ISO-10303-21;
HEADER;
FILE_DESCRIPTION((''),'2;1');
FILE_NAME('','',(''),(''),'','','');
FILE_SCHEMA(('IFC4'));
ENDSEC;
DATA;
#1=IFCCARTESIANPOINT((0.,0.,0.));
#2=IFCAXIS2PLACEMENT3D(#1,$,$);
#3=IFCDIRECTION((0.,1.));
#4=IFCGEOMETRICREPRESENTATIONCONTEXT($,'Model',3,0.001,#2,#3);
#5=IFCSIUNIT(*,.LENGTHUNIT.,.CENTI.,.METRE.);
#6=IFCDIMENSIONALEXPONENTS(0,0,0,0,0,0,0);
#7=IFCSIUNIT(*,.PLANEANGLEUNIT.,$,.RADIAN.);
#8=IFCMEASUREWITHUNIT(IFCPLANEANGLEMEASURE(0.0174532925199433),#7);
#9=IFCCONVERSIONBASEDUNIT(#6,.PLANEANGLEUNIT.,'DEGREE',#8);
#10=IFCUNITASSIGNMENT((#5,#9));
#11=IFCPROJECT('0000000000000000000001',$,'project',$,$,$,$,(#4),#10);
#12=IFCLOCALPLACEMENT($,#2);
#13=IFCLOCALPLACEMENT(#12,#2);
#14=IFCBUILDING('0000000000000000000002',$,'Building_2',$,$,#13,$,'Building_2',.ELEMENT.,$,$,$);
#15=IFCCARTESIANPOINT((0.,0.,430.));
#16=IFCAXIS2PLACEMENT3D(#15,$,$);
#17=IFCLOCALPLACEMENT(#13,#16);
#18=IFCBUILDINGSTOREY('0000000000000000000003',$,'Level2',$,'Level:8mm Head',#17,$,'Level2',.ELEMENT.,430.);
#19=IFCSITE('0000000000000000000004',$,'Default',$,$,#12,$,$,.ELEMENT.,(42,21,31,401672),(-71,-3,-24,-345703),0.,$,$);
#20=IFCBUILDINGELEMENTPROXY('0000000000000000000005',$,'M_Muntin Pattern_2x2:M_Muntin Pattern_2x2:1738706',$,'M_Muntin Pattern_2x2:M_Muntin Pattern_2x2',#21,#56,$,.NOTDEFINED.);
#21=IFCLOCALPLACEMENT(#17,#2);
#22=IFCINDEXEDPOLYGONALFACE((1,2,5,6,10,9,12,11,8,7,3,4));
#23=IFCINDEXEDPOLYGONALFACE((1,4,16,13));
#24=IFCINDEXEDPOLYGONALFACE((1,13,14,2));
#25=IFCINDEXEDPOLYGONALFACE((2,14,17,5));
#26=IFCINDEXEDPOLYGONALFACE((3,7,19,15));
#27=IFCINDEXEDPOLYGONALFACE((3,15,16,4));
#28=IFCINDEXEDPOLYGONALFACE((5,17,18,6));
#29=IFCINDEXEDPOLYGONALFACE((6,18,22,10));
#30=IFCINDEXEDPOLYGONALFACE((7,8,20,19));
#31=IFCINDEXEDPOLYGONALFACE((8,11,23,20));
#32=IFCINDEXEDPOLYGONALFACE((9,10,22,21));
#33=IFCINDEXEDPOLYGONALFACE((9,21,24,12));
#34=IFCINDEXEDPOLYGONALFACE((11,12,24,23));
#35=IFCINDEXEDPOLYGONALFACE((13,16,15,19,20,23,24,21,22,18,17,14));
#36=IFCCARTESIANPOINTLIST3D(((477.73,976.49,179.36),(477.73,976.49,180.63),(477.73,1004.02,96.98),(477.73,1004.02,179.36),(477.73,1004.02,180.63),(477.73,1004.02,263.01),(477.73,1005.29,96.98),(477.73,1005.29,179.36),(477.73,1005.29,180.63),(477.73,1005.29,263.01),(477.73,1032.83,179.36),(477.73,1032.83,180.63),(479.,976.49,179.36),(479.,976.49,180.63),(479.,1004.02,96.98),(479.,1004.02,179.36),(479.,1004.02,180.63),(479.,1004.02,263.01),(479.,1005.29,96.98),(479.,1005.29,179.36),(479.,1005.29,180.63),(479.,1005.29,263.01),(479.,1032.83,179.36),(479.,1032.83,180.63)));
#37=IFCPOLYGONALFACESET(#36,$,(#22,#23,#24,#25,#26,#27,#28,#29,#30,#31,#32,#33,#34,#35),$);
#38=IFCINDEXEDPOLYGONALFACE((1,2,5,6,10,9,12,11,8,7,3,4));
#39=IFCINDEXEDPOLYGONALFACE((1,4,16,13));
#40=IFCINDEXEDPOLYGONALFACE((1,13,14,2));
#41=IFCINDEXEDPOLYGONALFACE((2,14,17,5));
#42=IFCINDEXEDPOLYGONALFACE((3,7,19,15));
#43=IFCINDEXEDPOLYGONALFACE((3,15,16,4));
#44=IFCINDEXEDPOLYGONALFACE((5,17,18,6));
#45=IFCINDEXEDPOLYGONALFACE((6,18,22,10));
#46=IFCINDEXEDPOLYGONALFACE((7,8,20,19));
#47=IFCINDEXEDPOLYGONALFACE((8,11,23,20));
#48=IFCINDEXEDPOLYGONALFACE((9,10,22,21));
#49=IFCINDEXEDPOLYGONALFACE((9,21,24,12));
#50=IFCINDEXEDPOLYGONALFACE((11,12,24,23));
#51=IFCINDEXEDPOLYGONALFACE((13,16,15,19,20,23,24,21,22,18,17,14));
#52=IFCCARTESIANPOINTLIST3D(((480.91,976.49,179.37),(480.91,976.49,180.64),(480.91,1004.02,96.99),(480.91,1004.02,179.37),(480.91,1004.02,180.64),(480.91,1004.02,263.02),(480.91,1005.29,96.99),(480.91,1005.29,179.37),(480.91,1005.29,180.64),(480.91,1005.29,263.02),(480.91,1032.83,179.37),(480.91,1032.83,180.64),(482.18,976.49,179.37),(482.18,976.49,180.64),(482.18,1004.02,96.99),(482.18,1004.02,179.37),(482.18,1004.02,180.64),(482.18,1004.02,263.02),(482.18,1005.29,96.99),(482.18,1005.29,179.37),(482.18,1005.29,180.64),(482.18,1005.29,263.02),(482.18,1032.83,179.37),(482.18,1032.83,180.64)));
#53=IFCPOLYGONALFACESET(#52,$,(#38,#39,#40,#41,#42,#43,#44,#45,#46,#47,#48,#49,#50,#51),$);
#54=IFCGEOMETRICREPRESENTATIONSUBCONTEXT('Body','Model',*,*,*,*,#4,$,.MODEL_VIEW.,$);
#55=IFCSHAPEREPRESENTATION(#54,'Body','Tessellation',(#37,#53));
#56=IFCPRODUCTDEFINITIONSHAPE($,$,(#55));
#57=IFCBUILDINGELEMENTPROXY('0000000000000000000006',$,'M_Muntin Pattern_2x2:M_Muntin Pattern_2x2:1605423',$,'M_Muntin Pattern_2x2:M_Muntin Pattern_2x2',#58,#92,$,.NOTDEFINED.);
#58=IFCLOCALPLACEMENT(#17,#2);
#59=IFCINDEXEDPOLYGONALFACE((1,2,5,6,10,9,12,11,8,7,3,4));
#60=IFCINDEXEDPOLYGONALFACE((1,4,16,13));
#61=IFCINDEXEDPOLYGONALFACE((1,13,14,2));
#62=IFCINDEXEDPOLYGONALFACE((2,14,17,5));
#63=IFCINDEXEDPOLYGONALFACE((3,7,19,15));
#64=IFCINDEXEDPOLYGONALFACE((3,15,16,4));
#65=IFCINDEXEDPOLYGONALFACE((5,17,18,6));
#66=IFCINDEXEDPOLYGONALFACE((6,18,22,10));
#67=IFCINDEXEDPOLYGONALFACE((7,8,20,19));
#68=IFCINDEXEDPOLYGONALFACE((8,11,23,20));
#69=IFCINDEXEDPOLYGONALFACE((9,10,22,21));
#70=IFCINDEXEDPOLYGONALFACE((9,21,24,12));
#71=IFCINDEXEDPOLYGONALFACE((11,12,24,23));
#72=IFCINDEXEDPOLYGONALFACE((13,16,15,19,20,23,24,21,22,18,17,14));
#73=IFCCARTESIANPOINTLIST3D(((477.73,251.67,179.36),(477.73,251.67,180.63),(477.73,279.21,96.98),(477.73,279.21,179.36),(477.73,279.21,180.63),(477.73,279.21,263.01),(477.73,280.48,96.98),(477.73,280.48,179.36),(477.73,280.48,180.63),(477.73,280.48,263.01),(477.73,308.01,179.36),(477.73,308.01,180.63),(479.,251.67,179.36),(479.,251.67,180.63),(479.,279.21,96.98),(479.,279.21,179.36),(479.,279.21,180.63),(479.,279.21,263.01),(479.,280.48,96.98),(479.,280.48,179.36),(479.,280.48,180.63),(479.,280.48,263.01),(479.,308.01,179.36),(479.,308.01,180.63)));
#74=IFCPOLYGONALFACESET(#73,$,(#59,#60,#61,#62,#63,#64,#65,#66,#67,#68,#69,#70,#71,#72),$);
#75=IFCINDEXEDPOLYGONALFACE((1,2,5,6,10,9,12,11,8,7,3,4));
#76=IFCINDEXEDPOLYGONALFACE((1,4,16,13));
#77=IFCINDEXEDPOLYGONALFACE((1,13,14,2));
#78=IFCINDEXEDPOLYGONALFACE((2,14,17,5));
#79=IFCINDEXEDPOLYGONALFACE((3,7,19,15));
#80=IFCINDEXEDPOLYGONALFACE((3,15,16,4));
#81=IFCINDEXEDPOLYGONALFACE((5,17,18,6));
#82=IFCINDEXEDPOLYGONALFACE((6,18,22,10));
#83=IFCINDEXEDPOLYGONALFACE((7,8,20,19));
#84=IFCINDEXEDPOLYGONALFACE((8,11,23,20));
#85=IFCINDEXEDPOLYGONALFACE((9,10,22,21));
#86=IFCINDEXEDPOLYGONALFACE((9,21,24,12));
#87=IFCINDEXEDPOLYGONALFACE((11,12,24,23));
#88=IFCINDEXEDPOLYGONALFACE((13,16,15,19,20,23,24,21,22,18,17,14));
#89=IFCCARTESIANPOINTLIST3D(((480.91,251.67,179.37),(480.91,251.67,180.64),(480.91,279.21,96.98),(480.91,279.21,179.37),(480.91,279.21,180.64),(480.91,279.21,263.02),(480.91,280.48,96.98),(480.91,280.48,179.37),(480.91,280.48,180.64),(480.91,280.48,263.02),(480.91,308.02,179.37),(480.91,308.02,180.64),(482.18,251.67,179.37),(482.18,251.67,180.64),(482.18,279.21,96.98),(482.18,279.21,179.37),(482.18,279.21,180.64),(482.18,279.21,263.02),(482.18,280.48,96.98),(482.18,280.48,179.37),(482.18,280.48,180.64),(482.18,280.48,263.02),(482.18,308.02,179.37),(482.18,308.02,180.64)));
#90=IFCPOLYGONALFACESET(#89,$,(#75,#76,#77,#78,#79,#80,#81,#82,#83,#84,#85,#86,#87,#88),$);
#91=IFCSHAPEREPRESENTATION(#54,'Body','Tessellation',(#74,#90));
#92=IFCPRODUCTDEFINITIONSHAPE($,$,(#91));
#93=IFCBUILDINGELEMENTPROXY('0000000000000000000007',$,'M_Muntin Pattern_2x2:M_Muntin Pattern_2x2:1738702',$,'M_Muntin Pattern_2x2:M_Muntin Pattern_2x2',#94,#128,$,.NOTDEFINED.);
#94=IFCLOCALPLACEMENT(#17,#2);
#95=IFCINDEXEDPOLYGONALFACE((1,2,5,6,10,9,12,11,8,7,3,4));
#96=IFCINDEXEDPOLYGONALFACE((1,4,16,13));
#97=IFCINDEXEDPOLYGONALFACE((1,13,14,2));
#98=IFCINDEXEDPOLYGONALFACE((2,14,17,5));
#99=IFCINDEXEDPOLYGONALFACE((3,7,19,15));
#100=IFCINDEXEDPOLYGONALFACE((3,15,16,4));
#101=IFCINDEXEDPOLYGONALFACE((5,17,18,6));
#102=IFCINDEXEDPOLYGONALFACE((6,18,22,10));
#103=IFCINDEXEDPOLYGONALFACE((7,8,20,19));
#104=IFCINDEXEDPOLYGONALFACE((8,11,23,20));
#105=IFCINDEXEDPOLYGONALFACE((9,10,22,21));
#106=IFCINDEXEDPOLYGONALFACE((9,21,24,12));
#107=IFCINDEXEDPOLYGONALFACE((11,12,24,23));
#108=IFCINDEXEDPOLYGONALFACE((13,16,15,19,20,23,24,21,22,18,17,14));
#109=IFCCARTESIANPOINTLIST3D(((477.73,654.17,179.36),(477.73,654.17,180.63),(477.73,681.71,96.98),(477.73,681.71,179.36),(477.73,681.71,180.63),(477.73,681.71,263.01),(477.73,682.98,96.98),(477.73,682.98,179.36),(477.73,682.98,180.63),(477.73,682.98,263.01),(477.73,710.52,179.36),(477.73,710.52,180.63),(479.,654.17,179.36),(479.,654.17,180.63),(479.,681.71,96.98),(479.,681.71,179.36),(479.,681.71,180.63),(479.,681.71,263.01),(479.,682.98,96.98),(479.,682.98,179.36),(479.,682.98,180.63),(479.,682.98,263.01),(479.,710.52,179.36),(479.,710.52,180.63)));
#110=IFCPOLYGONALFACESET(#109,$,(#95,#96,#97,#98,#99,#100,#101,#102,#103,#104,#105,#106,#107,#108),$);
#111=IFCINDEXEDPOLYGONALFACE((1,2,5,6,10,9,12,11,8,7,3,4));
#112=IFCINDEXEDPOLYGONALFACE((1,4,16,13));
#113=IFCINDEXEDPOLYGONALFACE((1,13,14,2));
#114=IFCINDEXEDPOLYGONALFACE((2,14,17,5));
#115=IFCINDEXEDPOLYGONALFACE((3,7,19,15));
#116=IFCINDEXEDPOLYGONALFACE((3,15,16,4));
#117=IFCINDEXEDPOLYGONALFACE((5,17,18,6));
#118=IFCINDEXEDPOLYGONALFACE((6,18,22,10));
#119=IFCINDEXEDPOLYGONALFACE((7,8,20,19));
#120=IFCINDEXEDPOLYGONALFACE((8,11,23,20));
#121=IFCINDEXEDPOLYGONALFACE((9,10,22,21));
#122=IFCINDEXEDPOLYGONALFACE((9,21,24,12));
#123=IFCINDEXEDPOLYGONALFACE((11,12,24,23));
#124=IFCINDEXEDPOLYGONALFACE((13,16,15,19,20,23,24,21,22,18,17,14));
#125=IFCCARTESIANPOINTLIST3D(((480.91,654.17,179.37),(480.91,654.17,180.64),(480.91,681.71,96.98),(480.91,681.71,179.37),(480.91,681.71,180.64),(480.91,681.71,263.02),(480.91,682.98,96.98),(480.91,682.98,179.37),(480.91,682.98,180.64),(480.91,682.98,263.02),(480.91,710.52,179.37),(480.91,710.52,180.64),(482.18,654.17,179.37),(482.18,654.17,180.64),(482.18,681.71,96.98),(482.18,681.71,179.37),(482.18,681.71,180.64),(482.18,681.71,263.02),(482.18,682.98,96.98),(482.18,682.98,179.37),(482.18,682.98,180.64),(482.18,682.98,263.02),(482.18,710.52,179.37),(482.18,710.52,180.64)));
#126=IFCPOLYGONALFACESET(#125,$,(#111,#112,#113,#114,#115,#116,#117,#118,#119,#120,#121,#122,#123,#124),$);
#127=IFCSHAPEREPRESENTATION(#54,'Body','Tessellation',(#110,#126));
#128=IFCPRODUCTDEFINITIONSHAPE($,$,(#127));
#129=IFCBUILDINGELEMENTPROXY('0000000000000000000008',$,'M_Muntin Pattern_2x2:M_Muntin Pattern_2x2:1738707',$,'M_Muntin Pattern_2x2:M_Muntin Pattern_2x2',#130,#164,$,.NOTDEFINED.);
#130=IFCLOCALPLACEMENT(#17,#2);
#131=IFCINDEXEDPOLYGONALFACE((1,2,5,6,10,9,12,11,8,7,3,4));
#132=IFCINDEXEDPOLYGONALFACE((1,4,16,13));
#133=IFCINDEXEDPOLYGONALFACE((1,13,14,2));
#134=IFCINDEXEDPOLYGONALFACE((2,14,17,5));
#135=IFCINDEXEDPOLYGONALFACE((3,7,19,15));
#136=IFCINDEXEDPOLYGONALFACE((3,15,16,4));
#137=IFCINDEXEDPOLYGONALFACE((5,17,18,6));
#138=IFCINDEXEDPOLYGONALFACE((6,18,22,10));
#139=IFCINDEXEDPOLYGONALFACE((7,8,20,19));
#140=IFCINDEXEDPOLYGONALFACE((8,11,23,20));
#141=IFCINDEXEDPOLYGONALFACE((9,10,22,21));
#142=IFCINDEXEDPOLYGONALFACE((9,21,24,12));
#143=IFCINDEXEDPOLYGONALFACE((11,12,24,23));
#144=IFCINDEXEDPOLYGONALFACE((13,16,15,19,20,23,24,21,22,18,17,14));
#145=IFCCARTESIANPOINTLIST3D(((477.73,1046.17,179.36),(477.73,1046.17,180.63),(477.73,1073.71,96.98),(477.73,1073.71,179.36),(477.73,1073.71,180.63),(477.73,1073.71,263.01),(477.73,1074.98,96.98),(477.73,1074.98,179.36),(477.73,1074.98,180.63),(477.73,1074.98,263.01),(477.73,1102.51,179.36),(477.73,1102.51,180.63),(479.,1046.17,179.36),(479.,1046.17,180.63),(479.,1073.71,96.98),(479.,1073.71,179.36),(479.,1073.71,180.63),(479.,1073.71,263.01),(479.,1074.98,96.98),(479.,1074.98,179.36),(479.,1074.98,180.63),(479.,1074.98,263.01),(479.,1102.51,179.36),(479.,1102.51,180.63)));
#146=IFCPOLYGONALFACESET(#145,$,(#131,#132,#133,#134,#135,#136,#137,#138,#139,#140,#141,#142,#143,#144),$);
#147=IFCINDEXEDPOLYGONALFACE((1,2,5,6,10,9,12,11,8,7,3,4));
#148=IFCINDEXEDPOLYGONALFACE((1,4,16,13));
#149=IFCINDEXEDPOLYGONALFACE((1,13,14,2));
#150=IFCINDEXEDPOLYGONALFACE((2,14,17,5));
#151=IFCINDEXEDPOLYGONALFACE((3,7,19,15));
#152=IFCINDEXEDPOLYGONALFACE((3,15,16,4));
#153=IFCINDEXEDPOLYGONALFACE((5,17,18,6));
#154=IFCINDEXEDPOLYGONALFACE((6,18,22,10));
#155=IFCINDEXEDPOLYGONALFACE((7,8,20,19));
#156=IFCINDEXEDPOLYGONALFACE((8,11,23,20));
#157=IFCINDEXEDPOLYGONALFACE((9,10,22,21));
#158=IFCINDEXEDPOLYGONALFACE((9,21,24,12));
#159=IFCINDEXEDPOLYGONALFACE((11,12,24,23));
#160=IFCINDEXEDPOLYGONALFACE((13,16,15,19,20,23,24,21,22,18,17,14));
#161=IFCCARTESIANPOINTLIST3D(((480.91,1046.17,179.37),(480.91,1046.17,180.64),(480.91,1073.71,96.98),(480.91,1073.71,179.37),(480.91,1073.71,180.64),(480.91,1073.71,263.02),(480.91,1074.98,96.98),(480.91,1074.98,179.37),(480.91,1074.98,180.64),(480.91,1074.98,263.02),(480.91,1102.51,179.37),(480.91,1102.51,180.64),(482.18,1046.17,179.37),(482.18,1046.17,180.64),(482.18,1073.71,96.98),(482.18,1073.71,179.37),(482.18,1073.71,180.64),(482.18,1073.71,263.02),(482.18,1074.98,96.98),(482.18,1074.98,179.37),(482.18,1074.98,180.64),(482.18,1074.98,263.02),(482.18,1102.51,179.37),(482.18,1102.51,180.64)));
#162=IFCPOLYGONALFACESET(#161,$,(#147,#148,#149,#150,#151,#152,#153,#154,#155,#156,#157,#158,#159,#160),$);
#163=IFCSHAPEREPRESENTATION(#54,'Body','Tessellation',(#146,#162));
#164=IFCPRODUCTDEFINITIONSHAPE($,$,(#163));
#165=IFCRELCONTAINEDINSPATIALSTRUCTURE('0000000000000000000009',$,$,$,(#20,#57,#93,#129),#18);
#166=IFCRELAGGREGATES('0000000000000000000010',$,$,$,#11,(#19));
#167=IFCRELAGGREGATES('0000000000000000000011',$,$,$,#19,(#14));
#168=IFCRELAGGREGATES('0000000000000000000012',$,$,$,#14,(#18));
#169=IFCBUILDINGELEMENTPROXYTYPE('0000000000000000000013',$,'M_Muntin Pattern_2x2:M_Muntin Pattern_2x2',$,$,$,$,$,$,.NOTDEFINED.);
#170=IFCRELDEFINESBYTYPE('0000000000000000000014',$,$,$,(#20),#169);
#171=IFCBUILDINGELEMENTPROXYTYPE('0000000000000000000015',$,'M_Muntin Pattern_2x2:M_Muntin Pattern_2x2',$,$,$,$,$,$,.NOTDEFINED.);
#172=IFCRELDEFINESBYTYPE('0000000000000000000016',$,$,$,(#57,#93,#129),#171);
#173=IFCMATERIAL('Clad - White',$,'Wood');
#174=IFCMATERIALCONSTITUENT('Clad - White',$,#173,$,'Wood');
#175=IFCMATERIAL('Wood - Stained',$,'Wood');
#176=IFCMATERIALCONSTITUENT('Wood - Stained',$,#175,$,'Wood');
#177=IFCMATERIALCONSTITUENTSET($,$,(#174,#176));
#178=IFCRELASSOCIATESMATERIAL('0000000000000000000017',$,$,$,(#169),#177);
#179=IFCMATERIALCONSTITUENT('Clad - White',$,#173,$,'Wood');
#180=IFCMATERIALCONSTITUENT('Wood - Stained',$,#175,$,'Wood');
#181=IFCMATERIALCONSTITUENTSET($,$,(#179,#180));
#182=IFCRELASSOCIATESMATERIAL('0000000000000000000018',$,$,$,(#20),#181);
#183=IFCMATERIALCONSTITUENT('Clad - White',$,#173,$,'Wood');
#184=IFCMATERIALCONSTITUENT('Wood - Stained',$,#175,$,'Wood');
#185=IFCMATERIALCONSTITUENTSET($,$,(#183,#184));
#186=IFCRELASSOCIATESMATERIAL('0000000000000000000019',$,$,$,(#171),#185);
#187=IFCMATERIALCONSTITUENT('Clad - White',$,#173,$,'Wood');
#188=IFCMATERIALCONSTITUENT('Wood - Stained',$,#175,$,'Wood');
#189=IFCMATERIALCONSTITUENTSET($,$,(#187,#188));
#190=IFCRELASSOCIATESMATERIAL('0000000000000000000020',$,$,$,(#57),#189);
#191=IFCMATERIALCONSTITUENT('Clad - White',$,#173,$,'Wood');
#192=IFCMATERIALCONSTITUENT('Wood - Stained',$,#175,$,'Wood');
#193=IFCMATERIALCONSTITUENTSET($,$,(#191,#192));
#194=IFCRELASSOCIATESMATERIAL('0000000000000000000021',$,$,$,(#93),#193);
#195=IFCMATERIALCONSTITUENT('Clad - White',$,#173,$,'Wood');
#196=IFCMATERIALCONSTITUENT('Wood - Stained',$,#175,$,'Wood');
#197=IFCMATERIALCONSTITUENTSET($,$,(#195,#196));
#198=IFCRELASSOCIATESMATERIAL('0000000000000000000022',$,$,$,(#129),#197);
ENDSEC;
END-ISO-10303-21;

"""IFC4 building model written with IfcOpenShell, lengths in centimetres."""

from ifc_helpers import new_model, entity, si_unit, converted_unit, direction, frame, origin, place, context, subcontext, project, spatial, indexed_curve, outline, extrude, source, transform, mapped, material, constituent, constituent_set, type_object, type_shapes, element, save


model = new_model("IFC4")

# Units and contexts
model_context = context("Model", 3, precision=0.001, world=origin(), true_north=direction((0.0, 1.0)))
body_context = subcontext(model_context, "Body", "Model", "MODEL_VIEW")
ifc_project = project(units=[si_unit("LENGTHUNIT", "METRE", prefix="CENTI"), converted_unit("PLANEANGLEUNIT", "DEGREE", entity("IfcPlaneAngleMeasure", 0.0174532925199433), si_unit("PLANEANGLEUNIT", "RADIAN"), dimensions=[0, 0, 0, 0, 0, 0, 0])], contexts=[model_context])

# Site, building, storey
site_placement = place(None, origin())
site = spatial("IfcSite", under=ifc_project, at=site_placement, Name="Default", CompositionType="ELEMENT", RefLatitude=(42, 21, 31, 401672), RefLongitude=(-71, -3, -24, -345703), RefElevation=0.0)
building_placement = place(site_placement, origin())
building = spatial("IfcBuilding", under=site, at=building_placement, Name="Building_2", LongName="Building_2", CompositionType="ELEMENT")
storey_placement = place(building_placement, frame((0.0, 0.0, 430.0)))
storey = spatial("IfcBuildingStorey", under=building, at=storey_placement, Name="Level2", ObjectType="Level:8mm Head", LongName="Level2", CompositionType="ELEMENT", Elevation=430.0)

# Building element proxies
ifc_material_1 = material(Name="Clad - White", Category="Wood")
ifc_material_2 = material(Name="Wood - Stained", Category="Wood")
ifc_constituent_1 = constituent(ifc_material_1, Name="Clad - White", Category="Wood")
ifc_constituent_2 = constituent(ifc_material_2, Name="Wood - Stained", Category="Wood")
ifc_constituent_set_1 = constituent_set(constituents=[ifc_constituent_1, ifc_constituent_2])
building_element_proxy_type_1 = type_object("IfcBuildingElementProxyType", Name="M_Muntin Pattern_2x2:M_Muntin Pattern_2x2", PredefinedType="NOTDEFINED", material=ifc_constituent_set_1)
shared_shape_1 = source(origin(), body_context, "Body", "SweptSolid", [
    extrude(outline(indexed_curve([(0.64, -0.64), (83.01, -0.64), (83.01, 0.63), (0.64, 0.63), (0.64, 28.17), (-0.63, 28.17), (-0.63, 0.63), (-83.02, 0.63), (-83.02, -0.64), (-0.63, -0.64), (-0.63, -28.17), (0.64, -28.17), (0.64, -0.64)], self_intersect=False)), frame((0.0, 0.95, 83.01), z_axis=(0.0, 1.0, 0.0), x_axis=(0.0, 0.0, 1.0)), (0.0, 0.0, 1.0), 1.27),
    extrude(outline(indexed_curve([(0.64, -0.64), (83.02, -0.64), (83.02, 0.63), (0.64, 0.63), (0.64, 28.17), (-0.63, 28.17), (-0.63, 0.63), (-83.02, 0.63), (-83.02, -0.64), (-0.63, -0.64), (-0.63, -28.17), (0.64, -28.17), (0.64, -0.64)], self_intersect=False)), frame((0.0, -2.22, 83.02), z_axis=(0.0, 1.0, 0.0), x_axis=(0.0, 0.0, 1.0)), (0.0, 0.0, 1.0), 1.27),
])
type_shapes(building_element_proxy_type_1, [shared_shape_1])
ifc_constituent_3 = constituent(ifc_material_1, Name="Clad - White", Category="Wood")
ifc_constituent_4 = constituent(ifc_material_2, Name="Wood - Stained", Category="Wood")
ifc_constituent_set_2 = constituent_set(constituents=[ifc_constituent_3, ifc_constituent_4])
proxy_1_placement = place(storey_placement, frame((479.95, 1004.66, 96.99), z_axis=(0.0, 0.0, 1.0), x_axis=(0.0, 1.0, 0.0)))
element("IfcBuildingElementProxy", 1, at=proxy_1_placement, inside=storey, type_object=building_element_proxy_type_1, material=ifc_constituent_set_2, Name="M_Muntin Pattern_2x2:M_Muntin Pattern_2x2:1738706", ObjectType="M_Muntin Pattern_2x2:M_Muntin Pattern_2x2", PredefinedType="NOTDEFINED", context=body_context, shape_type="MappedRepresentation", body=[
    mapped(shared_shape_1, transform((0.0, 0.0, 0.0), scale=1.0)),
])
ifc_constituent_5 = constituent(ifc_material_1, Name="Clad - White", Category="Wood")
ifc_constituent_6 = constituent(ifc_material_2, Name="Wood - Stained", Category="Wood")
ifc_constituent_set_3 = constituent_set(constituents=[ifc_constituent_5, ifc_constituent_6])
ifc_constituent_7 = constituent(ifc_material_1, Name="Clad - White", Category="Wood")
ifc_constituent_8 = constituent(ifc_material_2, Name="Wood - Stained", Category="Wood")
ifc_constituent_set_4 = constituent_set(constituents=[ifc_constituent_7, ifc_constituent_8])
building_element_proxy_type_2 = type_object("IfcBuildingElementProxyType", Name="M_Muntin Pattern_2x2:M_Muntin Pattern_2x2", PredefinedType="NOTDEFINED", material=ifc_constituent_set_4)
shared_shape_2 = source(origin(), body_context, "Body", "SweptSolid", [
    extrude(outline(indexed_curve([(0.64, -0.64), (83.01, -0.64), (83.01, 0.63), (0.64, 0.63), (0.64, 28.17), (-0.63, 28.17), (-0.63, 0.63), (-83.02, 0.63), (-83.02, -0.64), (-0.63, -0.64), (-0.63, -28.17), (0.64, -28.17), (0.64, -0.64)], self_intersect=False)), frame((0.0, -2.22, 83.01), z_axis=(0.0, 1.0, 0.0), x_axis=(0.0, 0.0, 1.0)), (0.0, 0.0, 1.0), 1.27),
    extrude(outline(indexed_curve([(0.64, -0.64), (83.02, -0.64), (83.02, 0.63), (0.64, 0.63), (0.64, 28.17), (-0.63, 28.17), (-0.63, 0.63), (-83.02, 0.63), (-83.02, -0.64), (-0.63, -0.64), (-0.63, -28.17), (0.64, -28.17), (0.64, -0.64)], self_intersect=False)), frame((0.0, 0.95, 83.02), z_axis=(0.0, 1.0, 0.0), x_axis=(0.0, 0.0, 1.0)), (0.0, 0.0, 1.0), 1.27),
])
type_shapes(building_element_proxy_type_2, [shared_shape_2])
proxy_2_placement = place(storey_placement, frame((479.95, 279.84, 96.98), z_axis=(0.0, 0.0, 1.0), x_axis=(0.0, -1.0, 0.0)))
element("IfcBuildingElementProxy", 2, at=proxy_2_placement, inside=storey, type_object=building_element_proxy_type_2, material=ifc_constituent_set_3, Name="M_Muntin Pattern_2x2:M_Muntin Pattern_2x2:1605423", ObjectType="M_Muntin Pattern_2x2:M_Muntin Pattern_2x2", PredefinedType="NOTDEFINED", context=body_context, shape_type="MappedRepresentation", body=[
    mapped(shared_shape_2, transform((0.0, 0.0, 0.0), scale=1.0)),
])
ifc_constituent_9 = constituent(ifc_material_1, Name="Clad - White", Category="Wood")
ifc_constituent_10 = constituent(ifc_material_2, Name="Wood - Stained", Category="Wood")
ifc_constituent_set_5 = constituent_set(constituents=[ifc_constituent_9, ifc_constituent_10])
proxy_3_placement = place(storey_placement, frame((479.95, 682.34, 96.98), z_axis=(0.0, 0.0, 1.0), x_axis=(0.0, -1.0, 0.0)))
element("IfcBuildingElementProxy", 3, at=proxy_3_placement, inside=storey, type_object=building_element_proxy_type_2, material=ifc_constituent_set_5, Name="M_Muntin Pattern_2x2:M_Muntin Pattern_2x2:1738702", ObjectType="M_Muntin Pattern_2x2:M_Muntin Pattern_2x2", PredefinedType="NOTDEFINED", context=body_context, shape_type="MappedRepresentation", body=[
    mapped(shared_shape_2, transform((0.0, 0.0, 0.0), scale=1.0)),
])
ifc_constituent_11 = constituent(ifc_material_1, Name="Clad - White", Category="Wood")
ifc_constituent_12 = constituent(ifc_material_2, Name="Wood - Stained", Category="Wood")
ifc_constituent_set_6 = constituent_set(constituents=[ifc_constituent_11, ifc_constituent_12])
proxy_4_placement = place(storey_placement, frame((479.95, 1074.34, 96.98), z_axis=(0.0, 0.0, 1.0), x_axis=(0.0, -1.0, 0.0)))
element("IfcBuildingElementProxy", 4, at=proxy_4_placement, inside=storey, type_object=building_element_proxy_type_2, material=ifc_constituent_set_6, Name="M_Muntin Pattern_2x2:M_Muntin Pattern_2x2:1738707", ObjectType="M_Muntin Pattern_2x2:M_Muntin Pattern_2x2", PredefinedType="NOTDEFINED", context=body_context, shape_type="MappedRepresentation", body=[
    mapped(shared_shape_2, transform((0.0, 0.0, 0.0), scale=1.0)),
])

save(model, "model.ifc")
